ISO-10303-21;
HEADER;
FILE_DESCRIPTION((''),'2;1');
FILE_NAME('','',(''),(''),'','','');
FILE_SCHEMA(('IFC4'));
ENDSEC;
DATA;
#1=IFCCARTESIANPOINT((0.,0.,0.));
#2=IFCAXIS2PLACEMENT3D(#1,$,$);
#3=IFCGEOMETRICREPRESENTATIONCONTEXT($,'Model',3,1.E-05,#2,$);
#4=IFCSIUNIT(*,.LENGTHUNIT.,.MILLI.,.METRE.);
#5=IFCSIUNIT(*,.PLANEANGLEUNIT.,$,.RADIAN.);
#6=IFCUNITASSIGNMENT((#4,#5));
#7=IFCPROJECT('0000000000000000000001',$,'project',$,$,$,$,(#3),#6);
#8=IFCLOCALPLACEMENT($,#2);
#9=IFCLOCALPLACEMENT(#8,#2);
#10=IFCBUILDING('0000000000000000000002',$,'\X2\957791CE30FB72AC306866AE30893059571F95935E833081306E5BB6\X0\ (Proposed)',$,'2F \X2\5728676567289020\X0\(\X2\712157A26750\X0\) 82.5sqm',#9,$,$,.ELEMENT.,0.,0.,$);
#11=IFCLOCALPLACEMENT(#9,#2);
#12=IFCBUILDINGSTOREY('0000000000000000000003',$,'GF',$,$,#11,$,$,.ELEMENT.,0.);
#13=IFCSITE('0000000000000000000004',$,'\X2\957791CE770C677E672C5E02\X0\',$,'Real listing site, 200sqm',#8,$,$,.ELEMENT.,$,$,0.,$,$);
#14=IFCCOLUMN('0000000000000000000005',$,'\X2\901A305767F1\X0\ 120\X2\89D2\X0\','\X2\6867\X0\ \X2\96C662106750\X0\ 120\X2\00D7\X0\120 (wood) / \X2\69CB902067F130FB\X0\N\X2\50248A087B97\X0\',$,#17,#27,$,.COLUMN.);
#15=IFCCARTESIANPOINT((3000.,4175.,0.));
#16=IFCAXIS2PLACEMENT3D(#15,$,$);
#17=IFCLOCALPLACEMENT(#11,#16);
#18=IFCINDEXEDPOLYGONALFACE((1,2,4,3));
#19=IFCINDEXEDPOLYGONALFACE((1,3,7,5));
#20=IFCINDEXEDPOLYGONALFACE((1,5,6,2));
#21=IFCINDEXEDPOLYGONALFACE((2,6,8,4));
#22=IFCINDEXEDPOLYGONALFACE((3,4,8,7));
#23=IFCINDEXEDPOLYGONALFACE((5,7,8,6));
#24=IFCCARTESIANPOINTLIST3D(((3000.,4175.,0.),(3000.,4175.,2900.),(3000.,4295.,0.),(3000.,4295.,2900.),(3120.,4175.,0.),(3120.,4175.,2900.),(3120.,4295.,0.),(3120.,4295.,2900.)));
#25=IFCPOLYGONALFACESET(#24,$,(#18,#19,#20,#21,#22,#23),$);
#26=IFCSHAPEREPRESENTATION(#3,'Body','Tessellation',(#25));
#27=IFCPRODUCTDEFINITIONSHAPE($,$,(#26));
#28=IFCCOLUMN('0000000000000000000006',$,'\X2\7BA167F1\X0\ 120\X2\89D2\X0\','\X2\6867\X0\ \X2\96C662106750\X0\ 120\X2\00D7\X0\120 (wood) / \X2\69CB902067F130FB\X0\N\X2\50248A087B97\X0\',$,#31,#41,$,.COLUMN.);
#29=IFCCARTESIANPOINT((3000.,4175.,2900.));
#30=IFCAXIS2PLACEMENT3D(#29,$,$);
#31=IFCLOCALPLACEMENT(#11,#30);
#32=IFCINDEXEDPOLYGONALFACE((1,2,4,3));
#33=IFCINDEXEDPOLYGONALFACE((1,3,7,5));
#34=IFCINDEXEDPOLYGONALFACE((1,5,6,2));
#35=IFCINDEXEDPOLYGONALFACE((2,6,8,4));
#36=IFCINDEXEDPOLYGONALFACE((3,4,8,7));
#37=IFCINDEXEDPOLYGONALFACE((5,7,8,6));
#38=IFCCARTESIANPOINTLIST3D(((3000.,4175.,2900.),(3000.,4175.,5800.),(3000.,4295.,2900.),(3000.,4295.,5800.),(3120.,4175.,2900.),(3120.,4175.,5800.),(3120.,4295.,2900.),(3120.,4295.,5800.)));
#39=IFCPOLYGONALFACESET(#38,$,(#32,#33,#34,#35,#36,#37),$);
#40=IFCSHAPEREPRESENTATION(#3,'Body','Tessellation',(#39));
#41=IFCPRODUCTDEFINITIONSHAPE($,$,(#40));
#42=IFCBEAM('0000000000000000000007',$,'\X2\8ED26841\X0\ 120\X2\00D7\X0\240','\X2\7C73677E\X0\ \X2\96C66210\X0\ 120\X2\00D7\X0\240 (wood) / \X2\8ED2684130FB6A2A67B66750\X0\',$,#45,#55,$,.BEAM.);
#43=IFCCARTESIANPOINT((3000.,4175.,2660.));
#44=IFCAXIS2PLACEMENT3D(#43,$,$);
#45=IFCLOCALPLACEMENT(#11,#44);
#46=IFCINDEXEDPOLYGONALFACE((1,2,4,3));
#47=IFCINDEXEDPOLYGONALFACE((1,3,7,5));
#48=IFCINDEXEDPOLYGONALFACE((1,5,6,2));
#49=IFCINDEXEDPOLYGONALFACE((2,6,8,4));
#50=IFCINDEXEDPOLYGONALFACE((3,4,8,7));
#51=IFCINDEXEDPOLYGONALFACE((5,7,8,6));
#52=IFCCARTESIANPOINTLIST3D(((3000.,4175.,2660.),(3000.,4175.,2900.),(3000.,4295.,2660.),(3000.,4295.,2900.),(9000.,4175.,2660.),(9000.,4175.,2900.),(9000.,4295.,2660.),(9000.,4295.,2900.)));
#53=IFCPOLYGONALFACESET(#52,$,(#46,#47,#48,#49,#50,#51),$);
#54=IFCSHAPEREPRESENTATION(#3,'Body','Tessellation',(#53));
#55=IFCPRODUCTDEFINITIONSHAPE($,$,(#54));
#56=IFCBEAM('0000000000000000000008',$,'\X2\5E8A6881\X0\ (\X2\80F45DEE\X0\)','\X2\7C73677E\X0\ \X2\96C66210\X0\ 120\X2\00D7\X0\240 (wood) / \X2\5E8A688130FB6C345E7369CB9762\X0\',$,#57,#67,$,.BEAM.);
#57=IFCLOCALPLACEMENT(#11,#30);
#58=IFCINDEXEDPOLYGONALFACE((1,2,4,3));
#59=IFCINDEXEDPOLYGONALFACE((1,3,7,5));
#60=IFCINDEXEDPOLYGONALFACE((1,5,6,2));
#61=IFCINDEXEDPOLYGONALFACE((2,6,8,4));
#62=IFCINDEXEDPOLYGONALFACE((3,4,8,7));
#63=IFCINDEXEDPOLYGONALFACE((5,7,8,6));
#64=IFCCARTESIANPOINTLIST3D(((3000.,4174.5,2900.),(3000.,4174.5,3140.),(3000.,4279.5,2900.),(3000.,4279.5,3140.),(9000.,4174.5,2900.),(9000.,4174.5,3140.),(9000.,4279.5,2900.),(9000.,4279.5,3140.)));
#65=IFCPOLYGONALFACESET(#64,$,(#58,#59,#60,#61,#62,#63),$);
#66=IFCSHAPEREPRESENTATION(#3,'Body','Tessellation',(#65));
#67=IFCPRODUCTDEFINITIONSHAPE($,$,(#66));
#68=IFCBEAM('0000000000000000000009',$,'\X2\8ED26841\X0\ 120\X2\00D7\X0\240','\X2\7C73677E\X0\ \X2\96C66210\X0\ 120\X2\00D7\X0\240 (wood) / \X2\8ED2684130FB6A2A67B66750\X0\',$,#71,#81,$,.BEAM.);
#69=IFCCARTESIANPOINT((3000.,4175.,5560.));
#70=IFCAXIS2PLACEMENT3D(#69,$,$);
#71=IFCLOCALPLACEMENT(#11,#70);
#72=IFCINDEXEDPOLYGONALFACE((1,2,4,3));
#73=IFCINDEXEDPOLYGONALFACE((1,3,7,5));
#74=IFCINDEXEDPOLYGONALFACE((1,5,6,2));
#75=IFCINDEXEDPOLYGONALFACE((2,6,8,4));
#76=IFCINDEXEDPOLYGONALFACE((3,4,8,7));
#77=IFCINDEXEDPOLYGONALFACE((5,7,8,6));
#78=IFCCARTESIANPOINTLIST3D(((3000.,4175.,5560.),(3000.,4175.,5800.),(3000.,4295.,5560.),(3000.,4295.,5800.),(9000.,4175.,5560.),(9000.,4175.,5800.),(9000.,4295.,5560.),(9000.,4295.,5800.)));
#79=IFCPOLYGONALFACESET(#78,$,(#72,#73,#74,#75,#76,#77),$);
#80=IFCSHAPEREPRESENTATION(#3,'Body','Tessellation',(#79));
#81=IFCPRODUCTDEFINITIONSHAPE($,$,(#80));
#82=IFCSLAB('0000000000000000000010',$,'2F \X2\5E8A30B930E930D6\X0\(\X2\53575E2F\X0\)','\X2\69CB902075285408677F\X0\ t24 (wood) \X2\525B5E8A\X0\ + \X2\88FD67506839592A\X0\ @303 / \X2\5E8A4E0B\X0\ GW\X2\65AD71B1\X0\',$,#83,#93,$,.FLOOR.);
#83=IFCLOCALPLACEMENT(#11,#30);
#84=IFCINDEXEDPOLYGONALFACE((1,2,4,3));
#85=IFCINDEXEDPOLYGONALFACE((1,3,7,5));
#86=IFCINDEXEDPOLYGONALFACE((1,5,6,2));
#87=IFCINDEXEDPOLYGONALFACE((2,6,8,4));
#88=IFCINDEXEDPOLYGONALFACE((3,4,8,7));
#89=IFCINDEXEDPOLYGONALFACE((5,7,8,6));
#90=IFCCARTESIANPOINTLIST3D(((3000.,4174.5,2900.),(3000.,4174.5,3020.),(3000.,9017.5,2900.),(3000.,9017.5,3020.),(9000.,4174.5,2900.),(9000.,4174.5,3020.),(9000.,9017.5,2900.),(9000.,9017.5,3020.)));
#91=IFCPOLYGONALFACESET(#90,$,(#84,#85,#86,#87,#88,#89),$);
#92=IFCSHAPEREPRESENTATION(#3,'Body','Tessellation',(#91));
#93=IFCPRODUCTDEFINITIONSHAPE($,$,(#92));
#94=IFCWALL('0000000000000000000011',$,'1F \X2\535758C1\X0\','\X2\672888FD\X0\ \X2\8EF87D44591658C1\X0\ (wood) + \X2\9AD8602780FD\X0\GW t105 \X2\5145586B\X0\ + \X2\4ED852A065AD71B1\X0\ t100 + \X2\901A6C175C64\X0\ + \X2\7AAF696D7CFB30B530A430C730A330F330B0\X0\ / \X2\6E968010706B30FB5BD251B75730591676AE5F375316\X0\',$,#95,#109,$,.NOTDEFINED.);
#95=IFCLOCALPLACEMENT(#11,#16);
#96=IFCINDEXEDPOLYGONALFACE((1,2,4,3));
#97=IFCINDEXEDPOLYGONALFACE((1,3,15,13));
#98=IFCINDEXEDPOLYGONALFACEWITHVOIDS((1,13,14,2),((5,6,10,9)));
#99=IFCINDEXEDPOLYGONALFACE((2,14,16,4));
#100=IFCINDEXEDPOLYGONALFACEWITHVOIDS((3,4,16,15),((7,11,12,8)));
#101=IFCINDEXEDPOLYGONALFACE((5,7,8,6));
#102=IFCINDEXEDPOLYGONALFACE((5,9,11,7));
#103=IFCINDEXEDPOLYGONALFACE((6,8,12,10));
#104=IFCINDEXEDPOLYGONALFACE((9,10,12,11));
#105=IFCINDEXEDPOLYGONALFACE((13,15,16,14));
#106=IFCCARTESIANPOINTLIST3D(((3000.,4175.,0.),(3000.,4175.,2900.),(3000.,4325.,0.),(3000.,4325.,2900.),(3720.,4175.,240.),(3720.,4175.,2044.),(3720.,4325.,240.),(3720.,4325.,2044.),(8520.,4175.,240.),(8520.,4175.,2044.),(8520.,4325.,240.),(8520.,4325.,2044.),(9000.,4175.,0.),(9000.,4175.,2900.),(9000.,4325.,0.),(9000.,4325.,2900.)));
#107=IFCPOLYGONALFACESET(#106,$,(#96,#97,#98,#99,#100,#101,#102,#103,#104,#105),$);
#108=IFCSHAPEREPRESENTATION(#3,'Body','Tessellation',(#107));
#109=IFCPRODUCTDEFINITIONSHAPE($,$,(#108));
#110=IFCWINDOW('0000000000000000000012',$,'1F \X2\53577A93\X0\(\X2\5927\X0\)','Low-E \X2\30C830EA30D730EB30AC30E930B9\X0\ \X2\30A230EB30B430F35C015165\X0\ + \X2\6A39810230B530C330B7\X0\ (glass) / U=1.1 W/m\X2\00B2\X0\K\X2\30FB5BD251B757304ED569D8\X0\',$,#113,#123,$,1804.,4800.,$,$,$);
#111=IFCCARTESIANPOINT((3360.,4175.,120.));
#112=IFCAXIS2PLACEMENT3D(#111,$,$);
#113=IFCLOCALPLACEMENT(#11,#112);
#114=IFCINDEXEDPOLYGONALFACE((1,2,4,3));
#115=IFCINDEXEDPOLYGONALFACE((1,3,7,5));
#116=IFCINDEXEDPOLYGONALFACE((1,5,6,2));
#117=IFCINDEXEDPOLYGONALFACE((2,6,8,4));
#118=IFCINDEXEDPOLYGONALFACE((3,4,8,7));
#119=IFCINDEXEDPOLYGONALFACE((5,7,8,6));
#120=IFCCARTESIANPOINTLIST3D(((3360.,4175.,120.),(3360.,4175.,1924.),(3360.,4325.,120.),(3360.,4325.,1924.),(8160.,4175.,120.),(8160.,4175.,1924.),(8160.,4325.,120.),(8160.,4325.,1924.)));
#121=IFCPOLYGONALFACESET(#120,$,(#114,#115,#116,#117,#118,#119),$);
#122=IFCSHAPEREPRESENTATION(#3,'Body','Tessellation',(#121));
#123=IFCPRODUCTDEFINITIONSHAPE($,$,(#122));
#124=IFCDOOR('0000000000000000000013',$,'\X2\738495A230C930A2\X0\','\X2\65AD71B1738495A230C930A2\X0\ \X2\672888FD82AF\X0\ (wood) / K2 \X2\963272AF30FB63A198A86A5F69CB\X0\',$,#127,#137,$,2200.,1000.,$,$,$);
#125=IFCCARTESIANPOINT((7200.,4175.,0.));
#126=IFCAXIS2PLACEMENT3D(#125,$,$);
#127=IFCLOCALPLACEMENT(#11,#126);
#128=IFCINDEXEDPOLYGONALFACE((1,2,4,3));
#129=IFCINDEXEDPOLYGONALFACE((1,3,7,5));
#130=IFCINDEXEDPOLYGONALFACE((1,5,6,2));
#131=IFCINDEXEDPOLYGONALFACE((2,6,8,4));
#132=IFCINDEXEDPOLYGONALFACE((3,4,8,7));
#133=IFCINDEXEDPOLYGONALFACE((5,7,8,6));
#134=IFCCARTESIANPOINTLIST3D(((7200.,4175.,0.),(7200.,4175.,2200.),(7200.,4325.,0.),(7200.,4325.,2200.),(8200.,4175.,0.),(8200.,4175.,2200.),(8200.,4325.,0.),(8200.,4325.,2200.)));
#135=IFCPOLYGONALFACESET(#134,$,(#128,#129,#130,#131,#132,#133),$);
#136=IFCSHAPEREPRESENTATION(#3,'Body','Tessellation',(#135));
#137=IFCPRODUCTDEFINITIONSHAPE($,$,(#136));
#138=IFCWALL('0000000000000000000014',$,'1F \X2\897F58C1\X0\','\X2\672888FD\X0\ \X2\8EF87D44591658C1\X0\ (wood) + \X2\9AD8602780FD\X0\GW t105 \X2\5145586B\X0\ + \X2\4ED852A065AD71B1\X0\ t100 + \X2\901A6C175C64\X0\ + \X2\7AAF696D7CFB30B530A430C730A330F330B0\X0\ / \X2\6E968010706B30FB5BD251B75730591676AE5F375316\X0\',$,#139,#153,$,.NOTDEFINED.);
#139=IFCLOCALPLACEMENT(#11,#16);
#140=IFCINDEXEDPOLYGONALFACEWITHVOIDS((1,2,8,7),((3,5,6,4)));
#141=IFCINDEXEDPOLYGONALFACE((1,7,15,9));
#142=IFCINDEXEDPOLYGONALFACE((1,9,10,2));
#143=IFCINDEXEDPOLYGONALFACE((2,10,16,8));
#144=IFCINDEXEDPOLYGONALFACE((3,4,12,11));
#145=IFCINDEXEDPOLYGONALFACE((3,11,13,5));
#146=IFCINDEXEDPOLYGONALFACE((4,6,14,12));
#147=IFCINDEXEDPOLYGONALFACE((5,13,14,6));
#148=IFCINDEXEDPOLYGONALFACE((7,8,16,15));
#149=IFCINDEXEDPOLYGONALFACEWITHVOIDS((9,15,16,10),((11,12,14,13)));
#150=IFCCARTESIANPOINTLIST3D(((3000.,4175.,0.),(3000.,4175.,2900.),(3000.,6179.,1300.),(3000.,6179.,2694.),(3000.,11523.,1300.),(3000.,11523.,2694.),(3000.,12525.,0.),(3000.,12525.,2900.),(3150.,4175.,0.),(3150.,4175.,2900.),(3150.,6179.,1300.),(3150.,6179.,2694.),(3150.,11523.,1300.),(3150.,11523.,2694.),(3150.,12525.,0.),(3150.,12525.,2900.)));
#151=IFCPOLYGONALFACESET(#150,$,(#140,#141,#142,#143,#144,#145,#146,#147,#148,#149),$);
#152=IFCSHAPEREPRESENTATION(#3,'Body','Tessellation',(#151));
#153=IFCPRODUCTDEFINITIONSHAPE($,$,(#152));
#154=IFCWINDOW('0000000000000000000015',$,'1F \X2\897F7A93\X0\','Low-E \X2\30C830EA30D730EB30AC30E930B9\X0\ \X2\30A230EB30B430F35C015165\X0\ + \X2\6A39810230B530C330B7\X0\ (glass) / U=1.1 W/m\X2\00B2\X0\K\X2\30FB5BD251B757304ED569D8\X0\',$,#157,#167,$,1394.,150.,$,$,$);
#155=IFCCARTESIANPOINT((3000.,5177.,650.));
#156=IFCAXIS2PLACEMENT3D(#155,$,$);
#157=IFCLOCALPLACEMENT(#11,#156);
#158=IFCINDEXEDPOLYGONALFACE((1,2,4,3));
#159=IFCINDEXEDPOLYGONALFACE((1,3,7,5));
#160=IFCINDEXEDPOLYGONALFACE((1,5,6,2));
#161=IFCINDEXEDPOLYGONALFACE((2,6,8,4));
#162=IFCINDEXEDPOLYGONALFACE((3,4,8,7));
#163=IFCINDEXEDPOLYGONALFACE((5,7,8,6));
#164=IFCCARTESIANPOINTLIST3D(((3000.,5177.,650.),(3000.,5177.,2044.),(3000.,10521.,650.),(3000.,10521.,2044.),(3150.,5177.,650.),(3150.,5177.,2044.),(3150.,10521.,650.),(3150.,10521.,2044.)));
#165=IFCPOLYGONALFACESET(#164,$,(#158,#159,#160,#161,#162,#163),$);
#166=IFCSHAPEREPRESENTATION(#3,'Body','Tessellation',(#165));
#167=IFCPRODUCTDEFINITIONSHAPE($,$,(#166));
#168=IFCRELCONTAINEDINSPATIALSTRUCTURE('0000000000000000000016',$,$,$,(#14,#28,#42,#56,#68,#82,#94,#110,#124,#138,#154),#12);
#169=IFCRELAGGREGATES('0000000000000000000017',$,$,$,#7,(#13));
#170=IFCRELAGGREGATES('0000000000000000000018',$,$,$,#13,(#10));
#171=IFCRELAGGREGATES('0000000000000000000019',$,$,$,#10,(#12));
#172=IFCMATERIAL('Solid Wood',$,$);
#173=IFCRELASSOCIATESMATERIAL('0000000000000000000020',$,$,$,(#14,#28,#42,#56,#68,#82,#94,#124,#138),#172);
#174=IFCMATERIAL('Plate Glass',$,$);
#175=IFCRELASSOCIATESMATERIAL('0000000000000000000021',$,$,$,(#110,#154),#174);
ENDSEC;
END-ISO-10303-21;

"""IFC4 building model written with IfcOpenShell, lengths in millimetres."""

from ifc_helpers import new_model, si_unit, frame, frame_2d, origin, place, context, project, spatial, rectangle, extrude, material, element, fill, save


model = new_model("IFC4")

# Units and contexts
model_context = context("Model", 3, precision=1e-05, world=origin())
ifc_project = project(units=[si_unit("LENGTHUNIT", "METRE", prefix="MILLI"), si_unit("PLANEANGLEUNIT", "RADIAN")], contexts=[model_context])

# Site, building, storey
site_placement = place(None, origin())
site = spatial("IfcSite", under=ifc_project, at=site_placement, Name="長野県松本市", ObjectType="Real listing site, 200sqm", CompositionType="ELEMENT", RefElevation=0.0)
building_placement = place(site_placement, origin())
building = spatial("IfcBuilding", under=site, at=building_placement, Name="長野・犬と暮らす土間広めの家 (Proposed)", ObjectType="2F 在来木造(無垢材) 82.5sqm", CompositionType="ELEMENT", ElevationOfRefHeight=0.0, ElevationOfTerrain=0.0)
storey_placement = place(building_placement, origin())
storey = spatial("IfcBuildingStorey", under=building, at=storey_placement, Name="GF", CompositionType="ELEMENT", Elevation=0.0)

# Columns
ifc_material_1 = material(Name="Solid Wood")
column_1_placement = place(storey_placement, frame((3000.0, 4175.0, 0.0)))
element("IfcColumn", 1, at=column_1_placement, inside=storey, material=ifc_material_1, Name="通し柱 120角", Description="桧 集成材 120×120 (wood) / 構造柱・N値計算", PredefinedType="COLUMN", context=model_context, shape_type="SweptSolid", body=[
    extrude(rectangle(XDim=120.0, YDim=120.0, at=frame_2d((60.0, 60.0))), frame((3000.0, 4175.0, 0.0)), (0.0, 0.0, 1.0), 2900.0),
])
column_2_placement = place(storey_placement, frame((3000.0, 4175.0, 2900.0)))
element("IfcColumn", 2, at=column_2_placement, inside=storey, material=ifc_material_1, Name="管柱 120角", Description="桧 集成材 120×120 (wood) / 構造柱・N値計算", PredefinedType="COLUMN", context=model_context, shape_type="SweptSolid", body=[
    extrude(rectangle(XDim=120.0, YDim=120.0, at=frame_2d((60.0, 60.0))), frame((3000.0, 4175.0, 2900.0)), (0.0, 0.0, 1.0), 2900.0),
])

# Beams
beam_1_placement = place(storey_placement, frame((3000.0, 4175.0, 2660.0)))
element("IfcBeam", 3, at=beam_1_placement, inside=storey, material=ifc_material_1, Name="軒桁 120×240", Description="米松 集成 120×240 (wood) / 軒桁・横架材", PredefinedType="BEAM", context=model_context, shape_type="SweptSolid", body=[
    extrude(rectangle(XDim=6000.0, YDim=120.0, at=frame_2d((3000.0, 60.0))), frame((3000.0, 4175.0, 2660.0)), (0.0, 0.0, 1.0), 240.0),
])
beam_2_placement = place(storey_placement, frame((3000.0, 4175.0, 2900.0)))
element("IfcBeam", 4, at=beam_2_placement, inside=storey, material=ifc_material_1, Name="床梁 (胴差)", Description="米松 集成 120×240 (wood) / 床梁・水平構面", PredefinedType="BEAM", context=model_context, shape_type="SweptSolid", body=[
    extrude(rectangle(XDim=6000.0, YDim=105.0, at=frame_2d((3000.0, 52.0))), frame((3000.0, 4175.0, 2900.0)), (0.0, 0.0, 1.0), 240.0),
])
beam_3_placement = place(storey_placement, frame((3000.0, 4175.0, 5560.0)))
element("IfcBeam", 5, at=beam_3_placement, inside=storey, material=ifc_material_1, Name="軒桁 120×240", Description="米松 集成 120×240 (wood) / 軒桁・横架材", PredefinedType="BEAM", context=model_context, shape_type="SweptSolid", body=[
    extrude(rectangle(XDim=6000.0, YDim=120.0, at=frame_2d((3000.0, 60.0))), frame((3000.0, 4175.0, 5560.0)), (0.0, 0.0, 1.0), 240.0),
])

# Slab
slab_1_placement = place(storey_placement, frame((3000.0, 4175.0, 2900.0)))
element("IfcSlab", 6, at=slab_1_placement, inside=storey, material=ifc_material_1, Name="2F 床スラブ(南帯)", Description="構造用合板 t24 (wood) 剛床 + 製材根太 @303 / 床下 GW断熱", PredefinedType="FLOOR", context=model_context, shape_type="SweptSolid", body=[
    extrude(rectangle(XDim=6000.0, YDim=4843.0, at=frame_2d((3000.0, 2421.0))), frame((3000.0, 4175.0, 2900.0)), (0.0, 0.0, 1.0), 120.0),
])

# Wall, openings, window, door
wall_1_placement = place(storey_placement, frame((3000.0, 4175.0, 0.0)))
wall_1 = element("IfcWall", 7, at=wall_1_placement, inside=storey, material=ifc_material_1, Name="1F 南壁", Description="木製 軸組外壁 (wood) + 高性能GW t105 充填 + 付加断熱 t100 + 通気層 + 窯業系サイディング / 準耐火・寒冷地外皮強化", PredefinedType="NOTDEFINED", context=model_context, shape_type="SweptSolid", body=[
    extrude(rectangle(XDim=6000.0, YDim=150.0, at=frame_2d((3000.0, 75.0))), frame((3000.0, 4175.0, 0.0)), (0.0, 0.0, 1.0), 2900.0),
])
opening_1_placement = place(storey_placement, frame((3360.0, 4175.0, 120.0)))
opening_1 = element("IfcOpeningElement", 8, at=opening_1_placement, cuts=wall_1, PredefinedType="NOTDEFINED", context=model_context, shape_type="SweptSolid", body=[
    extrude(rectangle(XDim=4800.0, YDim=150.0, at=frame_2d((2400.0, 75.0))), frame((3360.0, 4175.0, 120.0)), (0.0, 0.0, 1.0), 1804.0),
])
opening_2_placement = place(storey_placement, frame((7200.0, 4175.0, 0.0)))
opening_2 = element("IfcOpeningElement", 9, at=opening_2_placement, cuts=wall_1, PredefinedType="NOTDEFINED", context=model_context, shape_type="SweptSolid", body=[
    extrude(rectangle(XDim=1000.0, YDim=150.0, at=frame_2d((500.0, 75.0))), frame((7200.0, 4175.0, 0.0)), (0.0, 0.0, 1.0), 2200.0),
])
ifc_material_2 = material(Name="Plate Glass")
window_1_placement = place(storey_placement, frame((3360.0, 4175.0, 120.0)))
window_1 = element("IfcWindow", 10, at=window_1_placement, inside=storey, material=ifc_material_2, Name="1F 南窓(大)", Description="Low-E トリプルガラス アルゴン封入 + 樹脂サッシ (glass) / U=1.1 W/m²K・寒冷地仕様", OverallHeight=1804.0, OverallWidth=4800.0, context=model_context, shape_type="SweptSolid", body=[
    extrude(rectangle(XDim=4800.0, YDim=150.0, at=frame_2d((2400.0, 75.0))), frame((3360.0, 4175.0, 120.0)), (0.0, 0.0, 1.0), 1804.0),
])
fill(opening_1, window_1)
door_placement = place(storey_placement, frame((7200.0, 4175.0, 0.0)))
door = element("IfcDoor", 11, at=door_placement, inside=storey, material=ifc_material_1, Name="玄関ドア", Description="断熱玄関ドア 木製芯 (wood) / K2 防犯・採風機構", OverallHeight=2200.0, OverallWidth=1000.0, context=model_context, shape_type="SweptSolid", body=[
    extrude(rectangle(XDim=1000.0, YDim=150.0, at=frame_2d((500.0, 75.0))), frame((7200.0, 4175.0, 0.0)), (0.0, 0.0, 1.0), 2200.0),
])
fill(opening_2, door)

# Wall, opening, window
wall_2_placement = place(storey_placement, frame((3000.0, 4175.0, 0.0)))
wall_2 = element("IfcWall", 12, at=wall_2_placement, inside=storey, material=ifc_material_1, Name="1F 西壁", Description="木製 軸組外壁 (wood) + 高性能GW t105 充填 + 付加断熱 t100 + 通気層 + 窯業系サイディング / 準耐火・寒冷地外皮強化", PredefinedType="NOTDEFINED", context=model_context, shape_type="SweptSolid", body=[
    extrude(rectangle(XDim=150.0, YDim=8350.0, at=frame_2d((75.0, 4175.0))), frame((3000.0, 4175.0, 0.0)), (0.0, 0.0, 1.0), 2900.0),
])
opening_3_placement = place(storey_placement, frame((3000.0, 5177.0, 650.0)))
opening_3 = element("IfcOpeningElement", 13, at=opening_3_placement, cuts=wall_2, PredefinedType="NOTDEFINED", context=model_context, shape_type="SweptSolid", body=[
    extrude(rectangle(XDim=150.0, YDim=5344.0, at=frame_2d((75.0, 2672.0))), frame((3000.0, 5177.0, 650.0)), (0.0, 0.0, 1.0), 1394.0),
])
window_2_placement = place(storey_placement, frame((3000.0, 5177.0, 650.0)))
window_2 = element("IfcWindow", 14, at=window_2_placement, inside=storey, material=ifc_material_2, Name="1F 西窓", Description="Low-E トリプルガラス アルゴン封入 + 樹脂サッシ (glass) / U=1.1 W/m²K・寒冷地仕様", OverallHeight=1394.0, OverallWidth=150.0, context=model_context, shape_type="SweptSolid", body=[
    extrude(rectangle(XDim=150.0, YDim=5344.0, at=frame_2d((75.0, 2672.0))), frame((3000.0, 5177.0, 650.0)), (0.0, 0.0, 1.0), 1394.0),
])
fill(opening_3, window_2)

save(model, "model.ifc")
